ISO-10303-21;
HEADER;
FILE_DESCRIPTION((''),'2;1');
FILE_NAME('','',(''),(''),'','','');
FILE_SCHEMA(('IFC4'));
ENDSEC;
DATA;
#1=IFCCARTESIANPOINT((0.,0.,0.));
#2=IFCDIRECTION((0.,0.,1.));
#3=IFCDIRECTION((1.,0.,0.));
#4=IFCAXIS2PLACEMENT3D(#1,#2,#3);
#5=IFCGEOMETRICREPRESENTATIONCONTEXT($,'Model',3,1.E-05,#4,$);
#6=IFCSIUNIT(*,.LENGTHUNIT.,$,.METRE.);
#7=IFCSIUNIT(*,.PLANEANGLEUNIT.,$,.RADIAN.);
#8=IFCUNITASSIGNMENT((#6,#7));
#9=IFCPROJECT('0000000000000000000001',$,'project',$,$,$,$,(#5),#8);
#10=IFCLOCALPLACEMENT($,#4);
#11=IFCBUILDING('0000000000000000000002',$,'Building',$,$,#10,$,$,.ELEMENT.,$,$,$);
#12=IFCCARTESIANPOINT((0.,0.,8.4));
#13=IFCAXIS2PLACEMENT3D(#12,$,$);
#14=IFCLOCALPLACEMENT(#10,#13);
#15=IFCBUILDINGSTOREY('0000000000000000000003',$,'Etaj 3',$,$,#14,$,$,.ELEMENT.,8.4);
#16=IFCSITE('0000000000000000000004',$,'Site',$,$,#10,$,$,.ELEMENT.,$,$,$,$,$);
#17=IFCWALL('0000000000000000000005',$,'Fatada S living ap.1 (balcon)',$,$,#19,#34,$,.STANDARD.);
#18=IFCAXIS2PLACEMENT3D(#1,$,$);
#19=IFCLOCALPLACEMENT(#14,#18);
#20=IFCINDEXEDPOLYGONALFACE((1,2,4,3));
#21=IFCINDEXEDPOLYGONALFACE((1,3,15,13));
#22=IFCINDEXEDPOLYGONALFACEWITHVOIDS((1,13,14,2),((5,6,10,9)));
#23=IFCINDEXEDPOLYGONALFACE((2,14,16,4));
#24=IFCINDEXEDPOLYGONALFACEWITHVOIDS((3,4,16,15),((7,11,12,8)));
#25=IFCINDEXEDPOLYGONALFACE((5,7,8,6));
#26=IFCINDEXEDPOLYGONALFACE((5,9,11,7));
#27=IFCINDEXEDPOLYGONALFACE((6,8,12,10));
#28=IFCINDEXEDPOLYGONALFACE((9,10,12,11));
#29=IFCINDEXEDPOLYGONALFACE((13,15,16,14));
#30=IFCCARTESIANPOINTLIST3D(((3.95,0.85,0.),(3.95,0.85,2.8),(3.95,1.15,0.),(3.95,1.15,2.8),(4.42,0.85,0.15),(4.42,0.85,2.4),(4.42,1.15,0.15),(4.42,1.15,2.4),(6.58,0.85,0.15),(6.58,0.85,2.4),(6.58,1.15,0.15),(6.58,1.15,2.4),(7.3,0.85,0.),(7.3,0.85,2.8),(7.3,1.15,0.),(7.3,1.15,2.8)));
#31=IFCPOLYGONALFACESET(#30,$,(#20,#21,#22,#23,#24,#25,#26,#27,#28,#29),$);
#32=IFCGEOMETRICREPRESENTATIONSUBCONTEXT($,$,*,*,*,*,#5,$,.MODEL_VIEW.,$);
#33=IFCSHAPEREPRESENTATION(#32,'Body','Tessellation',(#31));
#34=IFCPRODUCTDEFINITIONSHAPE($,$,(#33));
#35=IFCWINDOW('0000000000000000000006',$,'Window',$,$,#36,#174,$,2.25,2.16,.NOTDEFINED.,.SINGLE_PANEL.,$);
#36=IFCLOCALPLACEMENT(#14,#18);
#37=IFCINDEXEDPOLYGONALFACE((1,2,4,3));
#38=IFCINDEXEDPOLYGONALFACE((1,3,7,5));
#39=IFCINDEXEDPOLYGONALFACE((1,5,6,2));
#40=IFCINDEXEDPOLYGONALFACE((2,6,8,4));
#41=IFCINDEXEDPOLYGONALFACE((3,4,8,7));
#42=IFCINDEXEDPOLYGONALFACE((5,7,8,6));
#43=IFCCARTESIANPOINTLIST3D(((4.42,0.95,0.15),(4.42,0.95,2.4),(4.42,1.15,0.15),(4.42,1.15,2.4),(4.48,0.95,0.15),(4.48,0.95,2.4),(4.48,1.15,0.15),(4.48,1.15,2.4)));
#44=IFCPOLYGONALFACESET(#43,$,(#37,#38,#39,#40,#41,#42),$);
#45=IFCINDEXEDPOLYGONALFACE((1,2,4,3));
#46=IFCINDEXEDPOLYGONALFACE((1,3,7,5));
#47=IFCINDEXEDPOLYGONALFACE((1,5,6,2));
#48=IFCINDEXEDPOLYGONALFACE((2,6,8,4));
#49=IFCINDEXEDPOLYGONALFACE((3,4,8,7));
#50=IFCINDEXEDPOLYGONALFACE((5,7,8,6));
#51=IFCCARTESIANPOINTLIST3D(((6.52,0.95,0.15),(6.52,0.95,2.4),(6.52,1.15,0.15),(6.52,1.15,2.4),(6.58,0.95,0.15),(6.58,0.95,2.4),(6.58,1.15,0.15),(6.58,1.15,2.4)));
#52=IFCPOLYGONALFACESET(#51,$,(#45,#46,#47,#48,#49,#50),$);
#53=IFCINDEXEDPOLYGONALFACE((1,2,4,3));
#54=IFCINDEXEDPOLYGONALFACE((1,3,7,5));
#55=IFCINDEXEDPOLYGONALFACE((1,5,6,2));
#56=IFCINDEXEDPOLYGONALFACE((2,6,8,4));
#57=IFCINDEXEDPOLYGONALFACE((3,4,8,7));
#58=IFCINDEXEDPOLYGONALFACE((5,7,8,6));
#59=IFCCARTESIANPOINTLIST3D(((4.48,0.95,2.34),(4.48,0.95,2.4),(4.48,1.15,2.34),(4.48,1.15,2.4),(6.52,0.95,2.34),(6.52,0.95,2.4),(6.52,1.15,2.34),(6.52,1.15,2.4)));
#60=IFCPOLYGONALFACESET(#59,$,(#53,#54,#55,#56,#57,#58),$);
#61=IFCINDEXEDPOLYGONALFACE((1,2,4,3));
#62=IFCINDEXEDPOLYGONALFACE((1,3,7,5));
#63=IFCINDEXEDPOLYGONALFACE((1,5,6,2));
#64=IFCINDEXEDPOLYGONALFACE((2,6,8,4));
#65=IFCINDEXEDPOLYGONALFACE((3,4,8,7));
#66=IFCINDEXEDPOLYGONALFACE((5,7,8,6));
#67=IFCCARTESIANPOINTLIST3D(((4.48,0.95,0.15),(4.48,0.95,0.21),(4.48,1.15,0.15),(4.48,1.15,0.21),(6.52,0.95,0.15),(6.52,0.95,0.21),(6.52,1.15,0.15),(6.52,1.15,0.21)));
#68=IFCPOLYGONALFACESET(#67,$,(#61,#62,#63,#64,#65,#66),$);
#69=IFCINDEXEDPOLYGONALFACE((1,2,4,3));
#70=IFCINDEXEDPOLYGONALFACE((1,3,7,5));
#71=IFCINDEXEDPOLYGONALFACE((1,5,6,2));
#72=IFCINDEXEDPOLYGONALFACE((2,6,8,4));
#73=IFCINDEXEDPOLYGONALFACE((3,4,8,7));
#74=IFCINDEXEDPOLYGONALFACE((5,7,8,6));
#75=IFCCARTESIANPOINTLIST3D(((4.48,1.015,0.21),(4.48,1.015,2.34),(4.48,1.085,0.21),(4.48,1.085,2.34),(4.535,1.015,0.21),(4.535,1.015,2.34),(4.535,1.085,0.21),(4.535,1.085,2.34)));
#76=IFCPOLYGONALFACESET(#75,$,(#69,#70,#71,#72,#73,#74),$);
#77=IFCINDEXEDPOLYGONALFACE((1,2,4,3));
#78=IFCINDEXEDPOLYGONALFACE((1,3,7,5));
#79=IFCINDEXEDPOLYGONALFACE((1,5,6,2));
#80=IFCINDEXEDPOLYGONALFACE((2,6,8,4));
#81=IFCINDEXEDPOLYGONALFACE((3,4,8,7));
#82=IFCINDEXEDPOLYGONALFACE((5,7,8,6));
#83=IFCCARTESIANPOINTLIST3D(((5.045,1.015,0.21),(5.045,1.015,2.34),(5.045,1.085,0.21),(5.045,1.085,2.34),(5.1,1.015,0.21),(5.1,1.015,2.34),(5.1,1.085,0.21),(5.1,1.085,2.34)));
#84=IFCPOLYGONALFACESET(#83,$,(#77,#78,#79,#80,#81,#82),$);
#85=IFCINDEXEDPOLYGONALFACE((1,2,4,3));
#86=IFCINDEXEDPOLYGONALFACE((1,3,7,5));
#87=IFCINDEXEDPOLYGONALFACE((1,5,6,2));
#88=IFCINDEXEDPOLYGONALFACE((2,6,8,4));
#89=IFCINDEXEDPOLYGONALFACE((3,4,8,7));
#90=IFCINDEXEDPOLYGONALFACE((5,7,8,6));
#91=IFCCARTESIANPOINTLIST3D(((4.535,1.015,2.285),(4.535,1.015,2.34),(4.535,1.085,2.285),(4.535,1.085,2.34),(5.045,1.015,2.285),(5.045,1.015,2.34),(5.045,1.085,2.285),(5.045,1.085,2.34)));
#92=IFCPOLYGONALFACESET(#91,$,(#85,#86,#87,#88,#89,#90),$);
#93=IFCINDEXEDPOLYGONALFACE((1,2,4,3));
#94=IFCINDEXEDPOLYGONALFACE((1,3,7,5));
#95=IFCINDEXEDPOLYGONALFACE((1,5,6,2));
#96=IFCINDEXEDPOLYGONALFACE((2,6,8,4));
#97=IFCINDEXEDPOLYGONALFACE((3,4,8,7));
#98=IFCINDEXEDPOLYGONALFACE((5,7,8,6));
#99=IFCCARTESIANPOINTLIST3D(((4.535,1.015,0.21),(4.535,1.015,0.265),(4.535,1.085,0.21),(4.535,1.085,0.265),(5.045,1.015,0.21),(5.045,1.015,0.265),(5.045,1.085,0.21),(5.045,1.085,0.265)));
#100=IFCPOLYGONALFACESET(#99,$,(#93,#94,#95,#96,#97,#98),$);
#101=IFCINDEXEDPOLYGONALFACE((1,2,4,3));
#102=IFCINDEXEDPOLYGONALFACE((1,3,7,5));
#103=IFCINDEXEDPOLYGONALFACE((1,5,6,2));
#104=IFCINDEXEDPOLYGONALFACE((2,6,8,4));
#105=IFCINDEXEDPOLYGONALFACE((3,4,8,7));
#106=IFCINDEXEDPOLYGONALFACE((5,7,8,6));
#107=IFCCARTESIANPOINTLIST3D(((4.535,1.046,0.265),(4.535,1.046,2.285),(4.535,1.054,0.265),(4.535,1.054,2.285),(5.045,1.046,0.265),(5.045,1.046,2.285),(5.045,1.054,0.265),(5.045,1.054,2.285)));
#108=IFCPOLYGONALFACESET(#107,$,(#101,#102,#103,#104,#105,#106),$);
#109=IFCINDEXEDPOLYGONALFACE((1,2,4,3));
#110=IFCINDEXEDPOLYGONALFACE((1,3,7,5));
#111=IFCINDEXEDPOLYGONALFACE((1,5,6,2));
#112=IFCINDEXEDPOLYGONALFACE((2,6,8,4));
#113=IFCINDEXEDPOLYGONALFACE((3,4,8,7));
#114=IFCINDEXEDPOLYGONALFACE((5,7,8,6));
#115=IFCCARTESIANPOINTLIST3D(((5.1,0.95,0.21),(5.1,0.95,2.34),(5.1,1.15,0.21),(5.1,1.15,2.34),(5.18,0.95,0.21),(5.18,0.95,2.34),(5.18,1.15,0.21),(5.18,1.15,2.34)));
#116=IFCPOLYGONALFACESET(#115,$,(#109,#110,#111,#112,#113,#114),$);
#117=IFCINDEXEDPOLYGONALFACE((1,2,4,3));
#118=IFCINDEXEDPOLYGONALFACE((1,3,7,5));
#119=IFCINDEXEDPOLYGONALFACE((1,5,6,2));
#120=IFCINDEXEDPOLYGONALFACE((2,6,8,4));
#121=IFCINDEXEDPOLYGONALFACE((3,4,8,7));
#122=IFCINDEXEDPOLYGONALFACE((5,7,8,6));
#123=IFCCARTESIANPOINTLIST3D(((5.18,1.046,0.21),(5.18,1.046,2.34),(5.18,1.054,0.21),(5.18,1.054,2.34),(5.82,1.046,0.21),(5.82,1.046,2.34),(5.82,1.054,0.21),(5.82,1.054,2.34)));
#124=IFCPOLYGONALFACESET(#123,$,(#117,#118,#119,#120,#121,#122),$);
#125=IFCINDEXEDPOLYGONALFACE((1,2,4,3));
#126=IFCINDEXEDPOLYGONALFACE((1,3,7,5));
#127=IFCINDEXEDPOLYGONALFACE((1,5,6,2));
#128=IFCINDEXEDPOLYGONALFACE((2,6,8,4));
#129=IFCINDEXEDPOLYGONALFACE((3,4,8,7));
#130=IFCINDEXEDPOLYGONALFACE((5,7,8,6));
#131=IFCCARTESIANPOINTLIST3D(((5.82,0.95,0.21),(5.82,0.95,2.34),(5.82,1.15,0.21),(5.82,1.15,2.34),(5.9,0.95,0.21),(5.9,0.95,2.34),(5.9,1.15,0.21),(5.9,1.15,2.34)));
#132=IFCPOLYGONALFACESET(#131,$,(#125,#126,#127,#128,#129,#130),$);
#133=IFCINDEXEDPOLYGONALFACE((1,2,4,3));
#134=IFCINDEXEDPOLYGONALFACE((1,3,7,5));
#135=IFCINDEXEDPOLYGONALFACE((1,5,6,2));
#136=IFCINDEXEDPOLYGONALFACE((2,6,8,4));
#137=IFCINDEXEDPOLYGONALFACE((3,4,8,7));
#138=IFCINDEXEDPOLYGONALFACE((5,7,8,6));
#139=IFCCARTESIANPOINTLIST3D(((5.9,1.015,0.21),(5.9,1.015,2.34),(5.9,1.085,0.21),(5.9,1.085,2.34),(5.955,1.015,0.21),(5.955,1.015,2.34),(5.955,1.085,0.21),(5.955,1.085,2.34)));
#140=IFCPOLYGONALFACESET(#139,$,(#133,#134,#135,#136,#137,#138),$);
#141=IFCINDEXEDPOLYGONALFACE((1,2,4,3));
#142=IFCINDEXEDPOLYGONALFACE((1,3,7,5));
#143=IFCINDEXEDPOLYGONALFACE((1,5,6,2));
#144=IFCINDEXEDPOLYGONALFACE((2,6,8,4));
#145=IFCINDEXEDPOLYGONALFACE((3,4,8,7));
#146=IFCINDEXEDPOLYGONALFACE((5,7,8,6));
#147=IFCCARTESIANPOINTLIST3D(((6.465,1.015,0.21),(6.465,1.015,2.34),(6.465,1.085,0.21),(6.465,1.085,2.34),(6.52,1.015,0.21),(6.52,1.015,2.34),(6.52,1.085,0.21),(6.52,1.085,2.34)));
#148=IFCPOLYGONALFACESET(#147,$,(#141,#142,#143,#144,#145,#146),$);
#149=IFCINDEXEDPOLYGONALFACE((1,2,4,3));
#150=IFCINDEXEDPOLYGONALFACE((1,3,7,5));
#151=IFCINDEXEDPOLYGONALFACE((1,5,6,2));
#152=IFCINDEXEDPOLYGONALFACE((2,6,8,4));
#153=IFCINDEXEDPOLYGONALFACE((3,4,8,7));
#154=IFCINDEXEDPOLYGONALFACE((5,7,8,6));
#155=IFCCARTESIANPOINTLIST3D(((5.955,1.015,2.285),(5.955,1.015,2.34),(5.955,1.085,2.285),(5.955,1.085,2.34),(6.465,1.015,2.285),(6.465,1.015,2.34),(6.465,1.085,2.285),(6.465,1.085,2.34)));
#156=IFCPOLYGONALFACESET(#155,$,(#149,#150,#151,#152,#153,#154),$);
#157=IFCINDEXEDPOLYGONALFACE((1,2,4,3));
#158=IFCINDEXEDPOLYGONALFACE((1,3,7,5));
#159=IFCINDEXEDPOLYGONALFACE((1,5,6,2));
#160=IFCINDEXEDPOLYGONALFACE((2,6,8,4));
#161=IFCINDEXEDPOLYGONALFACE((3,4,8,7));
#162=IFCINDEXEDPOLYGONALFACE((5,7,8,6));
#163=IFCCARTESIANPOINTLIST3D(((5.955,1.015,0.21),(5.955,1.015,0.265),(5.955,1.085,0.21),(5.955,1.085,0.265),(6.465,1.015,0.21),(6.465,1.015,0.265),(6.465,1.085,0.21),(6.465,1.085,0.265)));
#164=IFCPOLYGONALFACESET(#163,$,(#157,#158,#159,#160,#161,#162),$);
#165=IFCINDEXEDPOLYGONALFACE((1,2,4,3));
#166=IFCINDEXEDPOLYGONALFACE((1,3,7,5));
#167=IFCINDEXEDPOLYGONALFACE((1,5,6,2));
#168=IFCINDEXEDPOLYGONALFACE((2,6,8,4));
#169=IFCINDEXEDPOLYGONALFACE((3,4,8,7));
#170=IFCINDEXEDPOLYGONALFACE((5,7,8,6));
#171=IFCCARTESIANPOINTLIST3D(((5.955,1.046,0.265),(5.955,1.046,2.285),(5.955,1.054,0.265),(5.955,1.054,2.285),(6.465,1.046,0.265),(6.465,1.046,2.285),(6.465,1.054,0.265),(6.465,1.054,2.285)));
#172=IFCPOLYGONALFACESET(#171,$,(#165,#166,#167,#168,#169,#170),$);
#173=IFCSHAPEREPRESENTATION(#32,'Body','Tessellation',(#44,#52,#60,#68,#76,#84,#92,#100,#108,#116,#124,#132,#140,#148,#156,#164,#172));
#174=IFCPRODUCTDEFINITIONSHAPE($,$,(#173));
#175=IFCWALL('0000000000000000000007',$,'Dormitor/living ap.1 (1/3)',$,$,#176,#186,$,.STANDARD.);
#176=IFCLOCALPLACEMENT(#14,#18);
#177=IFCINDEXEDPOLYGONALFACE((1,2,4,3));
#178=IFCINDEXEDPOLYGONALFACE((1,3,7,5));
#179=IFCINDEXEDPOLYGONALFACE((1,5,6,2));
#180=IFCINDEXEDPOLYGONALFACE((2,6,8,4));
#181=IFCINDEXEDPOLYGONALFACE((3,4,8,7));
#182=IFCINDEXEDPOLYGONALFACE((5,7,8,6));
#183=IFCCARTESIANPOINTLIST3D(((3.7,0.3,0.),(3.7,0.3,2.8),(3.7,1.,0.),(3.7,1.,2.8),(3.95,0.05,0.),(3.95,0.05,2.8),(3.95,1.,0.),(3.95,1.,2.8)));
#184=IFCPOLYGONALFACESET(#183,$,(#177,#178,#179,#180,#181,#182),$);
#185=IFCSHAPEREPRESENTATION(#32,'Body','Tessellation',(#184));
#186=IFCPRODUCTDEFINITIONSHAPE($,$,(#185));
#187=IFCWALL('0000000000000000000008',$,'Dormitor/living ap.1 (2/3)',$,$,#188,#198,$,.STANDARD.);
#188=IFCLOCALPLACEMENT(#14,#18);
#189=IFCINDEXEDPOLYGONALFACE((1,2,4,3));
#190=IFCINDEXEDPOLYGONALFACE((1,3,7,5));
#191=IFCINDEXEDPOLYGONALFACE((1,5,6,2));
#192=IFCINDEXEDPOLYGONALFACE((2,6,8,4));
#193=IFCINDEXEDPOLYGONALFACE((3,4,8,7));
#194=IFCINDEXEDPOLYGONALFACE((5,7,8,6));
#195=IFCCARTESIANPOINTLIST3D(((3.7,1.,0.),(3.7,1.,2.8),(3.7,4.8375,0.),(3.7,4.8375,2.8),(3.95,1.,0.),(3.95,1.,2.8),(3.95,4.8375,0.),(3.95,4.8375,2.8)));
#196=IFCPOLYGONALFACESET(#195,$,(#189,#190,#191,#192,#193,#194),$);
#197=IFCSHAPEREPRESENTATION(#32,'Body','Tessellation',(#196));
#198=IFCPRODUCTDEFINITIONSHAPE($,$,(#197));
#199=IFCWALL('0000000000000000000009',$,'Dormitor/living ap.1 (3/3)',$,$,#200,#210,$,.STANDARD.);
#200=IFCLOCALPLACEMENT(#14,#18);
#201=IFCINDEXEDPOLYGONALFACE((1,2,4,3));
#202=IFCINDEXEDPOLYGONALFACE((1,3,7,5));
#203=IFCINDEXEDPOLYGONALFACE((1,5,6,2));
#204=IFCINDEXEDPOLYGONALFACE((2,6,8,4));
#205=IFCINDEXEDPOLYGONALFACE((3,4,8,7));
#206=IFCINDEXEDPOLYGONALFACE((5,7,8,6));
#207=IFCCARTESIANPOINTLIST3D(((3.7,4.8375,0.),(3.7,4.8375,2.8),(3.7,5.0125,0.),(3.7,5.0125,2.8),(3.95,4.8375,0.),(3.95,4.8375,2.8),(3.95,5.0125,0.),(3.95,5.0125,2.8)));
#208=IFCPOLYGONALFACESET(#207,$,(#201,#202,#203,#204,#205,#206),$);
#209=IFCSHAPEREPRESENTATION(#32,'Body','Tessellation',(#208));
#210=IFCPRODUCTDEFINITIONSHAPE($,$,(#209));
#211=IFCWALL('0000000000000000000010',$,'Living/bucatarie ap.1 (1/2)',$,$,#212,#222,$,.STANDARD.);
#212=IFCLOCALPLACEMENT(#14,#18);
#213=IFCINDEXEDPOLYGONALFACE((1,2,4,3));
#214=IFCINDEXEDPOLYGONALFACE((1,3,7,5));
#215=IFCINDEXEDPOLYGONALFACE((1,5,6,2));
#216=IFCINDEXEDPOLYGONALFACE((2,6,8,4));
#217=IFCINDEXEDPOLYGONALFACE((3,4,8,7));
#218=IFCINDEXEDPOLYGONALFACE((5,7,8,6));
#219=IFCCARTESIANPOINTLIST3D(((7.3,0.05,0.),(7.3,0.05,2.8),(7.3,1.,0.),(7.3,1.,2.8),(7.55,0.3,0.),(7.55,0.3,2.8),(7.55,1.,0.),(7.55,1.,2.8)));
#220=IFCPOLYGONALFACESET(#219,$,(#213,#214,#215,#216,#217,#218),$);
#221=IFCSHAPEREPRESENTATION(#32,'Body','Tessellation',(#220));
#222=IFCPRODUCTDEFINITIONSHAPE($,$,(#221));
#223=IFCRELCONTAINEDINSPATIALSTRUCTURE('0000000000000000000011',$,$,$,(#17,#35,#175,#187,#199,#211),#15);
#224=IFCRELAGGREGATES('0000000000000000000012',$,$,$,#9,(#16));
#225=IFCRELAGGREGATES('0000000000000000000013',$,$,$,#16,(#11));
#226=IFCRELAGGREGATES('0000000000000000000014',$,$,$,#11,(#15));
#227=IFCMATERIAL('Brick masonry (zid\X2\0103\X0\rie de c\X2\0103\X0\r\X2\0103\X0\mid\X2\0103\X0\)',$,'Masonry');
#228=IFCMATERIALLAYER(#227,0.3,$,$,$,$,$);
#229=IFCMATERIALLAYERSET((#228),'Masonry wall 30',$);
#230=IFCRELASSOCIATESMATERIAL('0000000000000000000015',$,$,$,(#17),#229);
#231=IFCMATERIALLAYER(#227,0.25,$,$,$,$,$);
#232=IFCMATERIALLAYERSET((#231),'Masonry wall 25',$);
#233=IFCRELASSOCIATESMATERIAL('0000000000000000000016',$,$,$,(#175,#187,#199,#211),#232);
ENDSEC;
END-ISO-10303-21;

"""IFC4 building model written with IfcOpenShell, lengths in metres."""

from ifc_helpers import new_model, si_unit, frame, frame_2d, origin, origin_with_axes, origin_2d, place, context, subcontext, project, spatial, rectangle, extrude, clip, halfspace, material, layer, layer_set, layer_usage, element, fill, save


model = new_model("IFC4")

# Units and contexts
model_context = context("Model", 3, precision=1e-05, world=origin_with_axes())
sub_context = subcontext(model_context, None, None, "MODEL_VIEW")
ifc_project = project(units=[si_unit("LENGTHUNIT", "METRE"), si_unit("PLANEANGLEUNIT", "RADIAN")], contexts=[model_context])

# Site, building, storey
placement = place(None, origin_with_axes())
site = spatial("IfcSite", under=ifc_project, at=placement, Name="Site", CompositionType="ELEMENT")
building = spatial("IfcBuilding", under=site, at=placement, Name="Building", CompositionType="ELEMENT")
storey_placement = place(placement, frame((0.0, 0.0, 8.4)))
storey = spatial("IfcBuildingStorey", under=building, at=storey_placement, Name="Etaj 3", CompositionType="ELEMENT", Elevation=8.4)

# Wall, opening, window
ifc_material_1 = material(Name="Brick masonry (zidărie de cărămidă)", Category="Masonry")
ifc_layer_1 = layer(ifc_material_1, 0.3)
ifc_layer_set_1 = layer_set([ifc_layer_1], Name="Masonry wall 30")
ifc_layer_usage_1 = layer_usage(ifc_layer_set_1, "AXIS2", "POSITIVE", -0.15)
wall_1_placement = place(storey_placement, frame((3.95, 1.0, 0.0), x_axis=(1.0, 0.0, 0.0)))
wall_1 = element("IfcWall", 1, at=wall_1_placement, inside=storey, material=ifc_layer_usage_1, Name="Fatada S living ap.1 (balcon)", PredefinedType="STANDARD", context=sub_context, shape_type="SweptSolid", body=[
    extrude(rectangle(XDim=3.35, YDim=0.3, at=frame_2d((1.675, 0.0))), origin(), (0.0, 0.0, 1.0), 2.8),
])
opening_1_placement = place(wall_1_placement, frame((1.55, 0.2, 0.15), z_axis=(0.0, -1.0, 0.0), x_axis=(1.0, 0.0, 0.0)))
opening_1 = element("IfcOpeningElement", 2, at=opening_1_placement, cuts=wall_1, PredefinedType="OPENING", context=sub_context, shape_type="SweptSolid", body=[
    extrude(rectangle(XDim=2.16, YDim=2.25, at=frame_2d((0.0, 1.125))), origin(), (0.0, 0.0, 1.0), 0.4),
])
window_1_placement = place(wall_1_placement, frame((1.55, 0.15, 0.15), z_axis=(0.0, -1.0, 0.0), x_axis=(1.0, 0.0, 0.0)))
window_1 = element("IfcWindow", 3, at=window_1_placement, inside=storey, Name="Window", OverallHeight=2.25, OverallWidth=2.16, PartitioningType="SINGLE_PANEL", PredefinedType="NOTDEFINED", context=sub_context, shape_type="SweptSolid", body=[
    extrude(rectangle(XDim=0.06, YDim=2.25, at=origin_2d()), frame((-1.05, 1.125, 0.0)), (0.0, 0.0, 1.0), 0.2),
    extrude(rectangle(XDim=0.06, YDim=2.25, at=origin_2d()), frame((1.05, 1.125, 0.0)), (0.0, 0.0, 1.0), 0.2),
    extrude(rectangle(XDim=2.04, YDim=0.06, at=origin_2d()), frame((0.0, 2.22, 0.0)), (0.0, 0.0, 1.0), 0.2),
    extrude(rectangle(XDim=2.04, YDim=0.06, at=origin_2d()), frame((0.0, 0.03, 0.0)), (0.0, 0.0, 1.0), 0.2),
    extrude(rectangle(XDim=0.055, YDim=2.13, at=origin_2d()), frame((-0.9925, 1.125, 0.065)), (0.0, 0.0, 1.0), 0.07),
    extrude(rectangle(XDim=0.055, YDim=2.13, at=origin_2d()), frame((-0.4275, 1.125, 0.065)), (0.0, 0.0, 1.0), 0.07),
    extrude(rectangle(XDim=0.51, YDim=0.055, at=origin_2d()), frame((-0.71, 2.1625, 0.065)), (0.0, 0.0, 1.0), 0.07),
    extrude(rectangle(XDim=0.51, YDim=0.055, at=origin_2d()), frame((-0.71, 0.0875, 0.065)), (0.0, 0.0, 1.0), 0.07),
    extrude(rectangle(XDim=0.51, YDim=2.02, at=origin_2d()), frame((-0.71, 1.125, 0.096)), (0.0, 0.0, 1.0), 0.008),
    extrude(rectangle(XDim=0.08, YDim=2.13, at=origin_2d()), frame((-0.36, 1.125, 0.0)), (0.0, 0.0, 1.0), 0.2),
    extrude(rectangle(XDim=0.64, YDim=2.13, at=origin_2d()), frame((0.0, 1.125, 0.096)), (0.0, 0.0, 1.0), 0.008),
    extrude(rectangle(XDim=0.08, YDim=2.13, at=origin_2d()), frame((0.36, 1.125, 0.0)), (0.0, 0.0, 1.0), 0.2),
    extrude(rectangle(XDim=0.055, YDim=2.13, at=origin_2d()), frame((0.4275, 1.125, 0.065)), (0.0, 0.0, 1.0), 0.07),
    extrude(rectangle(XDim=0.055, YDim=2.13, at=origin_2d()), frame((0.9925, 1.125, 0.065)), (0.0, 0.0, 1.0), 0.07),
    extrude(rectangle(XDim=0.51, YDim=0.055, at=origin_2d()), frame((0.71, 2.1625, 0.065)), (0.0, 0.0, 1.0), 0.07),
    extrude(rectangle(XDim=0.51, YDim=0.055, at=origin_2d()), frame((0.71, 0.0875, 0.065)), (0.0, 0.0, 1.0), 0.07),
    extrude(rectangle(XDim=0.51, YDim=2.02, at=origin_2d()), frame((0.71, 1.125, 0.096)), (0.0, 0.0, 1.0), 0.008),
])
fill(opening_1, window_1)

# Walls
ifc_layer_2 = layer(ifc_material_1, 0.25)
ifc_layer_set_2 = layer_set([ifc_layer_2], Name="Masonry wall 25")
ifc_layer_usage_2 = layer_usage(ifc_layer_set_2, "AXIS2", "POSITIVE", -0.125)
wall_2_placement = place(storey_placement, frame((3.825, 0.05, 0.0), x_axis=(0.0, 1.0, 0.0)))
element("IfcWall", 4, at=wall_2_placement, inside=storey, material=ifc_layer_usage_2, Name="Dormitor/living ap.1 (1/3)", PredefinedType="STANDARD", context=sub_context, shape_type="CSG", body=[
    clip(extrude(rectangle(XDim=0.95, YDim=0.25, at=frame_2d((0.475, 0.0))), origin(), (0.0, 0.0, 1.0), 2.8), halfspace(frame((0.125, 0.0, 0.0), z_axis=(-0.707107, 0.707107, 0.0)), False)),
])
wall_3_placement = place(storey_placement, frame((3.825, 1.0, 0.0), x_axis=(0.0, 1.0, 0.0)))
element("IfcWall", 5, at=wall_3_placement, inside=storey, material=ifc_layer_usage_2, Name="Dormitor/living ap.1 (2/3)", PredefinedType="STANDARD", context=sub_context, shape_type="SweptSolid", body=[
    extrude(rectangle(XDim=3.8375, YDim=0.25, at=frame_2d((1.9188, 0.0))), origin(), (0.0, 0.0, 1.0), 2.8),
])
wall_4_placement = place(storey_placement, frame((3.825, 4.8375, 0.0), x_axis=(0.0, 1.0, 0.0)))
element("IfcWall", 6, at=wall_4_placement, inside=storey, material=ifc_layer_usage_2, Name="Dormitor/living ap.1 (3/3)", PredefinedType="STANDARD", context=sub_context, shape_type="SweptSolid", body=[
    extrude(rectangle(XDim=0.175, YDim=0.25, at=frame_2d((0.0875, 0.0))), origin(), (0.0, 0.0, 1.0), 2.8),
])
wall_5_placement = place(storey_placement, frame((7.425, 0.05, 0.0), x_axis=(0.0, 1.0, 0.0)))
element("IfcWall", 7, at=wall_5_placement, inside=storey, material=ifc_layer_usage_2, Name="Living/bucatarie ap.1 (1/2)", PredefinedType="STANDARD", context=sub_context, shape_type="CSG", body=[
    clip(extrude(rectangle(XDim=0.95, YDim=0.25, at=frame_2d((0.475, 0.0))), origin(), (0.0, 0.0, 1.0), 2.8), halfspace(frame((0.125, 0.0, 0.0), z_axis=(-0.707107, -0.707107, 0.0)), False)),
])

save(model, "model.ifc")
